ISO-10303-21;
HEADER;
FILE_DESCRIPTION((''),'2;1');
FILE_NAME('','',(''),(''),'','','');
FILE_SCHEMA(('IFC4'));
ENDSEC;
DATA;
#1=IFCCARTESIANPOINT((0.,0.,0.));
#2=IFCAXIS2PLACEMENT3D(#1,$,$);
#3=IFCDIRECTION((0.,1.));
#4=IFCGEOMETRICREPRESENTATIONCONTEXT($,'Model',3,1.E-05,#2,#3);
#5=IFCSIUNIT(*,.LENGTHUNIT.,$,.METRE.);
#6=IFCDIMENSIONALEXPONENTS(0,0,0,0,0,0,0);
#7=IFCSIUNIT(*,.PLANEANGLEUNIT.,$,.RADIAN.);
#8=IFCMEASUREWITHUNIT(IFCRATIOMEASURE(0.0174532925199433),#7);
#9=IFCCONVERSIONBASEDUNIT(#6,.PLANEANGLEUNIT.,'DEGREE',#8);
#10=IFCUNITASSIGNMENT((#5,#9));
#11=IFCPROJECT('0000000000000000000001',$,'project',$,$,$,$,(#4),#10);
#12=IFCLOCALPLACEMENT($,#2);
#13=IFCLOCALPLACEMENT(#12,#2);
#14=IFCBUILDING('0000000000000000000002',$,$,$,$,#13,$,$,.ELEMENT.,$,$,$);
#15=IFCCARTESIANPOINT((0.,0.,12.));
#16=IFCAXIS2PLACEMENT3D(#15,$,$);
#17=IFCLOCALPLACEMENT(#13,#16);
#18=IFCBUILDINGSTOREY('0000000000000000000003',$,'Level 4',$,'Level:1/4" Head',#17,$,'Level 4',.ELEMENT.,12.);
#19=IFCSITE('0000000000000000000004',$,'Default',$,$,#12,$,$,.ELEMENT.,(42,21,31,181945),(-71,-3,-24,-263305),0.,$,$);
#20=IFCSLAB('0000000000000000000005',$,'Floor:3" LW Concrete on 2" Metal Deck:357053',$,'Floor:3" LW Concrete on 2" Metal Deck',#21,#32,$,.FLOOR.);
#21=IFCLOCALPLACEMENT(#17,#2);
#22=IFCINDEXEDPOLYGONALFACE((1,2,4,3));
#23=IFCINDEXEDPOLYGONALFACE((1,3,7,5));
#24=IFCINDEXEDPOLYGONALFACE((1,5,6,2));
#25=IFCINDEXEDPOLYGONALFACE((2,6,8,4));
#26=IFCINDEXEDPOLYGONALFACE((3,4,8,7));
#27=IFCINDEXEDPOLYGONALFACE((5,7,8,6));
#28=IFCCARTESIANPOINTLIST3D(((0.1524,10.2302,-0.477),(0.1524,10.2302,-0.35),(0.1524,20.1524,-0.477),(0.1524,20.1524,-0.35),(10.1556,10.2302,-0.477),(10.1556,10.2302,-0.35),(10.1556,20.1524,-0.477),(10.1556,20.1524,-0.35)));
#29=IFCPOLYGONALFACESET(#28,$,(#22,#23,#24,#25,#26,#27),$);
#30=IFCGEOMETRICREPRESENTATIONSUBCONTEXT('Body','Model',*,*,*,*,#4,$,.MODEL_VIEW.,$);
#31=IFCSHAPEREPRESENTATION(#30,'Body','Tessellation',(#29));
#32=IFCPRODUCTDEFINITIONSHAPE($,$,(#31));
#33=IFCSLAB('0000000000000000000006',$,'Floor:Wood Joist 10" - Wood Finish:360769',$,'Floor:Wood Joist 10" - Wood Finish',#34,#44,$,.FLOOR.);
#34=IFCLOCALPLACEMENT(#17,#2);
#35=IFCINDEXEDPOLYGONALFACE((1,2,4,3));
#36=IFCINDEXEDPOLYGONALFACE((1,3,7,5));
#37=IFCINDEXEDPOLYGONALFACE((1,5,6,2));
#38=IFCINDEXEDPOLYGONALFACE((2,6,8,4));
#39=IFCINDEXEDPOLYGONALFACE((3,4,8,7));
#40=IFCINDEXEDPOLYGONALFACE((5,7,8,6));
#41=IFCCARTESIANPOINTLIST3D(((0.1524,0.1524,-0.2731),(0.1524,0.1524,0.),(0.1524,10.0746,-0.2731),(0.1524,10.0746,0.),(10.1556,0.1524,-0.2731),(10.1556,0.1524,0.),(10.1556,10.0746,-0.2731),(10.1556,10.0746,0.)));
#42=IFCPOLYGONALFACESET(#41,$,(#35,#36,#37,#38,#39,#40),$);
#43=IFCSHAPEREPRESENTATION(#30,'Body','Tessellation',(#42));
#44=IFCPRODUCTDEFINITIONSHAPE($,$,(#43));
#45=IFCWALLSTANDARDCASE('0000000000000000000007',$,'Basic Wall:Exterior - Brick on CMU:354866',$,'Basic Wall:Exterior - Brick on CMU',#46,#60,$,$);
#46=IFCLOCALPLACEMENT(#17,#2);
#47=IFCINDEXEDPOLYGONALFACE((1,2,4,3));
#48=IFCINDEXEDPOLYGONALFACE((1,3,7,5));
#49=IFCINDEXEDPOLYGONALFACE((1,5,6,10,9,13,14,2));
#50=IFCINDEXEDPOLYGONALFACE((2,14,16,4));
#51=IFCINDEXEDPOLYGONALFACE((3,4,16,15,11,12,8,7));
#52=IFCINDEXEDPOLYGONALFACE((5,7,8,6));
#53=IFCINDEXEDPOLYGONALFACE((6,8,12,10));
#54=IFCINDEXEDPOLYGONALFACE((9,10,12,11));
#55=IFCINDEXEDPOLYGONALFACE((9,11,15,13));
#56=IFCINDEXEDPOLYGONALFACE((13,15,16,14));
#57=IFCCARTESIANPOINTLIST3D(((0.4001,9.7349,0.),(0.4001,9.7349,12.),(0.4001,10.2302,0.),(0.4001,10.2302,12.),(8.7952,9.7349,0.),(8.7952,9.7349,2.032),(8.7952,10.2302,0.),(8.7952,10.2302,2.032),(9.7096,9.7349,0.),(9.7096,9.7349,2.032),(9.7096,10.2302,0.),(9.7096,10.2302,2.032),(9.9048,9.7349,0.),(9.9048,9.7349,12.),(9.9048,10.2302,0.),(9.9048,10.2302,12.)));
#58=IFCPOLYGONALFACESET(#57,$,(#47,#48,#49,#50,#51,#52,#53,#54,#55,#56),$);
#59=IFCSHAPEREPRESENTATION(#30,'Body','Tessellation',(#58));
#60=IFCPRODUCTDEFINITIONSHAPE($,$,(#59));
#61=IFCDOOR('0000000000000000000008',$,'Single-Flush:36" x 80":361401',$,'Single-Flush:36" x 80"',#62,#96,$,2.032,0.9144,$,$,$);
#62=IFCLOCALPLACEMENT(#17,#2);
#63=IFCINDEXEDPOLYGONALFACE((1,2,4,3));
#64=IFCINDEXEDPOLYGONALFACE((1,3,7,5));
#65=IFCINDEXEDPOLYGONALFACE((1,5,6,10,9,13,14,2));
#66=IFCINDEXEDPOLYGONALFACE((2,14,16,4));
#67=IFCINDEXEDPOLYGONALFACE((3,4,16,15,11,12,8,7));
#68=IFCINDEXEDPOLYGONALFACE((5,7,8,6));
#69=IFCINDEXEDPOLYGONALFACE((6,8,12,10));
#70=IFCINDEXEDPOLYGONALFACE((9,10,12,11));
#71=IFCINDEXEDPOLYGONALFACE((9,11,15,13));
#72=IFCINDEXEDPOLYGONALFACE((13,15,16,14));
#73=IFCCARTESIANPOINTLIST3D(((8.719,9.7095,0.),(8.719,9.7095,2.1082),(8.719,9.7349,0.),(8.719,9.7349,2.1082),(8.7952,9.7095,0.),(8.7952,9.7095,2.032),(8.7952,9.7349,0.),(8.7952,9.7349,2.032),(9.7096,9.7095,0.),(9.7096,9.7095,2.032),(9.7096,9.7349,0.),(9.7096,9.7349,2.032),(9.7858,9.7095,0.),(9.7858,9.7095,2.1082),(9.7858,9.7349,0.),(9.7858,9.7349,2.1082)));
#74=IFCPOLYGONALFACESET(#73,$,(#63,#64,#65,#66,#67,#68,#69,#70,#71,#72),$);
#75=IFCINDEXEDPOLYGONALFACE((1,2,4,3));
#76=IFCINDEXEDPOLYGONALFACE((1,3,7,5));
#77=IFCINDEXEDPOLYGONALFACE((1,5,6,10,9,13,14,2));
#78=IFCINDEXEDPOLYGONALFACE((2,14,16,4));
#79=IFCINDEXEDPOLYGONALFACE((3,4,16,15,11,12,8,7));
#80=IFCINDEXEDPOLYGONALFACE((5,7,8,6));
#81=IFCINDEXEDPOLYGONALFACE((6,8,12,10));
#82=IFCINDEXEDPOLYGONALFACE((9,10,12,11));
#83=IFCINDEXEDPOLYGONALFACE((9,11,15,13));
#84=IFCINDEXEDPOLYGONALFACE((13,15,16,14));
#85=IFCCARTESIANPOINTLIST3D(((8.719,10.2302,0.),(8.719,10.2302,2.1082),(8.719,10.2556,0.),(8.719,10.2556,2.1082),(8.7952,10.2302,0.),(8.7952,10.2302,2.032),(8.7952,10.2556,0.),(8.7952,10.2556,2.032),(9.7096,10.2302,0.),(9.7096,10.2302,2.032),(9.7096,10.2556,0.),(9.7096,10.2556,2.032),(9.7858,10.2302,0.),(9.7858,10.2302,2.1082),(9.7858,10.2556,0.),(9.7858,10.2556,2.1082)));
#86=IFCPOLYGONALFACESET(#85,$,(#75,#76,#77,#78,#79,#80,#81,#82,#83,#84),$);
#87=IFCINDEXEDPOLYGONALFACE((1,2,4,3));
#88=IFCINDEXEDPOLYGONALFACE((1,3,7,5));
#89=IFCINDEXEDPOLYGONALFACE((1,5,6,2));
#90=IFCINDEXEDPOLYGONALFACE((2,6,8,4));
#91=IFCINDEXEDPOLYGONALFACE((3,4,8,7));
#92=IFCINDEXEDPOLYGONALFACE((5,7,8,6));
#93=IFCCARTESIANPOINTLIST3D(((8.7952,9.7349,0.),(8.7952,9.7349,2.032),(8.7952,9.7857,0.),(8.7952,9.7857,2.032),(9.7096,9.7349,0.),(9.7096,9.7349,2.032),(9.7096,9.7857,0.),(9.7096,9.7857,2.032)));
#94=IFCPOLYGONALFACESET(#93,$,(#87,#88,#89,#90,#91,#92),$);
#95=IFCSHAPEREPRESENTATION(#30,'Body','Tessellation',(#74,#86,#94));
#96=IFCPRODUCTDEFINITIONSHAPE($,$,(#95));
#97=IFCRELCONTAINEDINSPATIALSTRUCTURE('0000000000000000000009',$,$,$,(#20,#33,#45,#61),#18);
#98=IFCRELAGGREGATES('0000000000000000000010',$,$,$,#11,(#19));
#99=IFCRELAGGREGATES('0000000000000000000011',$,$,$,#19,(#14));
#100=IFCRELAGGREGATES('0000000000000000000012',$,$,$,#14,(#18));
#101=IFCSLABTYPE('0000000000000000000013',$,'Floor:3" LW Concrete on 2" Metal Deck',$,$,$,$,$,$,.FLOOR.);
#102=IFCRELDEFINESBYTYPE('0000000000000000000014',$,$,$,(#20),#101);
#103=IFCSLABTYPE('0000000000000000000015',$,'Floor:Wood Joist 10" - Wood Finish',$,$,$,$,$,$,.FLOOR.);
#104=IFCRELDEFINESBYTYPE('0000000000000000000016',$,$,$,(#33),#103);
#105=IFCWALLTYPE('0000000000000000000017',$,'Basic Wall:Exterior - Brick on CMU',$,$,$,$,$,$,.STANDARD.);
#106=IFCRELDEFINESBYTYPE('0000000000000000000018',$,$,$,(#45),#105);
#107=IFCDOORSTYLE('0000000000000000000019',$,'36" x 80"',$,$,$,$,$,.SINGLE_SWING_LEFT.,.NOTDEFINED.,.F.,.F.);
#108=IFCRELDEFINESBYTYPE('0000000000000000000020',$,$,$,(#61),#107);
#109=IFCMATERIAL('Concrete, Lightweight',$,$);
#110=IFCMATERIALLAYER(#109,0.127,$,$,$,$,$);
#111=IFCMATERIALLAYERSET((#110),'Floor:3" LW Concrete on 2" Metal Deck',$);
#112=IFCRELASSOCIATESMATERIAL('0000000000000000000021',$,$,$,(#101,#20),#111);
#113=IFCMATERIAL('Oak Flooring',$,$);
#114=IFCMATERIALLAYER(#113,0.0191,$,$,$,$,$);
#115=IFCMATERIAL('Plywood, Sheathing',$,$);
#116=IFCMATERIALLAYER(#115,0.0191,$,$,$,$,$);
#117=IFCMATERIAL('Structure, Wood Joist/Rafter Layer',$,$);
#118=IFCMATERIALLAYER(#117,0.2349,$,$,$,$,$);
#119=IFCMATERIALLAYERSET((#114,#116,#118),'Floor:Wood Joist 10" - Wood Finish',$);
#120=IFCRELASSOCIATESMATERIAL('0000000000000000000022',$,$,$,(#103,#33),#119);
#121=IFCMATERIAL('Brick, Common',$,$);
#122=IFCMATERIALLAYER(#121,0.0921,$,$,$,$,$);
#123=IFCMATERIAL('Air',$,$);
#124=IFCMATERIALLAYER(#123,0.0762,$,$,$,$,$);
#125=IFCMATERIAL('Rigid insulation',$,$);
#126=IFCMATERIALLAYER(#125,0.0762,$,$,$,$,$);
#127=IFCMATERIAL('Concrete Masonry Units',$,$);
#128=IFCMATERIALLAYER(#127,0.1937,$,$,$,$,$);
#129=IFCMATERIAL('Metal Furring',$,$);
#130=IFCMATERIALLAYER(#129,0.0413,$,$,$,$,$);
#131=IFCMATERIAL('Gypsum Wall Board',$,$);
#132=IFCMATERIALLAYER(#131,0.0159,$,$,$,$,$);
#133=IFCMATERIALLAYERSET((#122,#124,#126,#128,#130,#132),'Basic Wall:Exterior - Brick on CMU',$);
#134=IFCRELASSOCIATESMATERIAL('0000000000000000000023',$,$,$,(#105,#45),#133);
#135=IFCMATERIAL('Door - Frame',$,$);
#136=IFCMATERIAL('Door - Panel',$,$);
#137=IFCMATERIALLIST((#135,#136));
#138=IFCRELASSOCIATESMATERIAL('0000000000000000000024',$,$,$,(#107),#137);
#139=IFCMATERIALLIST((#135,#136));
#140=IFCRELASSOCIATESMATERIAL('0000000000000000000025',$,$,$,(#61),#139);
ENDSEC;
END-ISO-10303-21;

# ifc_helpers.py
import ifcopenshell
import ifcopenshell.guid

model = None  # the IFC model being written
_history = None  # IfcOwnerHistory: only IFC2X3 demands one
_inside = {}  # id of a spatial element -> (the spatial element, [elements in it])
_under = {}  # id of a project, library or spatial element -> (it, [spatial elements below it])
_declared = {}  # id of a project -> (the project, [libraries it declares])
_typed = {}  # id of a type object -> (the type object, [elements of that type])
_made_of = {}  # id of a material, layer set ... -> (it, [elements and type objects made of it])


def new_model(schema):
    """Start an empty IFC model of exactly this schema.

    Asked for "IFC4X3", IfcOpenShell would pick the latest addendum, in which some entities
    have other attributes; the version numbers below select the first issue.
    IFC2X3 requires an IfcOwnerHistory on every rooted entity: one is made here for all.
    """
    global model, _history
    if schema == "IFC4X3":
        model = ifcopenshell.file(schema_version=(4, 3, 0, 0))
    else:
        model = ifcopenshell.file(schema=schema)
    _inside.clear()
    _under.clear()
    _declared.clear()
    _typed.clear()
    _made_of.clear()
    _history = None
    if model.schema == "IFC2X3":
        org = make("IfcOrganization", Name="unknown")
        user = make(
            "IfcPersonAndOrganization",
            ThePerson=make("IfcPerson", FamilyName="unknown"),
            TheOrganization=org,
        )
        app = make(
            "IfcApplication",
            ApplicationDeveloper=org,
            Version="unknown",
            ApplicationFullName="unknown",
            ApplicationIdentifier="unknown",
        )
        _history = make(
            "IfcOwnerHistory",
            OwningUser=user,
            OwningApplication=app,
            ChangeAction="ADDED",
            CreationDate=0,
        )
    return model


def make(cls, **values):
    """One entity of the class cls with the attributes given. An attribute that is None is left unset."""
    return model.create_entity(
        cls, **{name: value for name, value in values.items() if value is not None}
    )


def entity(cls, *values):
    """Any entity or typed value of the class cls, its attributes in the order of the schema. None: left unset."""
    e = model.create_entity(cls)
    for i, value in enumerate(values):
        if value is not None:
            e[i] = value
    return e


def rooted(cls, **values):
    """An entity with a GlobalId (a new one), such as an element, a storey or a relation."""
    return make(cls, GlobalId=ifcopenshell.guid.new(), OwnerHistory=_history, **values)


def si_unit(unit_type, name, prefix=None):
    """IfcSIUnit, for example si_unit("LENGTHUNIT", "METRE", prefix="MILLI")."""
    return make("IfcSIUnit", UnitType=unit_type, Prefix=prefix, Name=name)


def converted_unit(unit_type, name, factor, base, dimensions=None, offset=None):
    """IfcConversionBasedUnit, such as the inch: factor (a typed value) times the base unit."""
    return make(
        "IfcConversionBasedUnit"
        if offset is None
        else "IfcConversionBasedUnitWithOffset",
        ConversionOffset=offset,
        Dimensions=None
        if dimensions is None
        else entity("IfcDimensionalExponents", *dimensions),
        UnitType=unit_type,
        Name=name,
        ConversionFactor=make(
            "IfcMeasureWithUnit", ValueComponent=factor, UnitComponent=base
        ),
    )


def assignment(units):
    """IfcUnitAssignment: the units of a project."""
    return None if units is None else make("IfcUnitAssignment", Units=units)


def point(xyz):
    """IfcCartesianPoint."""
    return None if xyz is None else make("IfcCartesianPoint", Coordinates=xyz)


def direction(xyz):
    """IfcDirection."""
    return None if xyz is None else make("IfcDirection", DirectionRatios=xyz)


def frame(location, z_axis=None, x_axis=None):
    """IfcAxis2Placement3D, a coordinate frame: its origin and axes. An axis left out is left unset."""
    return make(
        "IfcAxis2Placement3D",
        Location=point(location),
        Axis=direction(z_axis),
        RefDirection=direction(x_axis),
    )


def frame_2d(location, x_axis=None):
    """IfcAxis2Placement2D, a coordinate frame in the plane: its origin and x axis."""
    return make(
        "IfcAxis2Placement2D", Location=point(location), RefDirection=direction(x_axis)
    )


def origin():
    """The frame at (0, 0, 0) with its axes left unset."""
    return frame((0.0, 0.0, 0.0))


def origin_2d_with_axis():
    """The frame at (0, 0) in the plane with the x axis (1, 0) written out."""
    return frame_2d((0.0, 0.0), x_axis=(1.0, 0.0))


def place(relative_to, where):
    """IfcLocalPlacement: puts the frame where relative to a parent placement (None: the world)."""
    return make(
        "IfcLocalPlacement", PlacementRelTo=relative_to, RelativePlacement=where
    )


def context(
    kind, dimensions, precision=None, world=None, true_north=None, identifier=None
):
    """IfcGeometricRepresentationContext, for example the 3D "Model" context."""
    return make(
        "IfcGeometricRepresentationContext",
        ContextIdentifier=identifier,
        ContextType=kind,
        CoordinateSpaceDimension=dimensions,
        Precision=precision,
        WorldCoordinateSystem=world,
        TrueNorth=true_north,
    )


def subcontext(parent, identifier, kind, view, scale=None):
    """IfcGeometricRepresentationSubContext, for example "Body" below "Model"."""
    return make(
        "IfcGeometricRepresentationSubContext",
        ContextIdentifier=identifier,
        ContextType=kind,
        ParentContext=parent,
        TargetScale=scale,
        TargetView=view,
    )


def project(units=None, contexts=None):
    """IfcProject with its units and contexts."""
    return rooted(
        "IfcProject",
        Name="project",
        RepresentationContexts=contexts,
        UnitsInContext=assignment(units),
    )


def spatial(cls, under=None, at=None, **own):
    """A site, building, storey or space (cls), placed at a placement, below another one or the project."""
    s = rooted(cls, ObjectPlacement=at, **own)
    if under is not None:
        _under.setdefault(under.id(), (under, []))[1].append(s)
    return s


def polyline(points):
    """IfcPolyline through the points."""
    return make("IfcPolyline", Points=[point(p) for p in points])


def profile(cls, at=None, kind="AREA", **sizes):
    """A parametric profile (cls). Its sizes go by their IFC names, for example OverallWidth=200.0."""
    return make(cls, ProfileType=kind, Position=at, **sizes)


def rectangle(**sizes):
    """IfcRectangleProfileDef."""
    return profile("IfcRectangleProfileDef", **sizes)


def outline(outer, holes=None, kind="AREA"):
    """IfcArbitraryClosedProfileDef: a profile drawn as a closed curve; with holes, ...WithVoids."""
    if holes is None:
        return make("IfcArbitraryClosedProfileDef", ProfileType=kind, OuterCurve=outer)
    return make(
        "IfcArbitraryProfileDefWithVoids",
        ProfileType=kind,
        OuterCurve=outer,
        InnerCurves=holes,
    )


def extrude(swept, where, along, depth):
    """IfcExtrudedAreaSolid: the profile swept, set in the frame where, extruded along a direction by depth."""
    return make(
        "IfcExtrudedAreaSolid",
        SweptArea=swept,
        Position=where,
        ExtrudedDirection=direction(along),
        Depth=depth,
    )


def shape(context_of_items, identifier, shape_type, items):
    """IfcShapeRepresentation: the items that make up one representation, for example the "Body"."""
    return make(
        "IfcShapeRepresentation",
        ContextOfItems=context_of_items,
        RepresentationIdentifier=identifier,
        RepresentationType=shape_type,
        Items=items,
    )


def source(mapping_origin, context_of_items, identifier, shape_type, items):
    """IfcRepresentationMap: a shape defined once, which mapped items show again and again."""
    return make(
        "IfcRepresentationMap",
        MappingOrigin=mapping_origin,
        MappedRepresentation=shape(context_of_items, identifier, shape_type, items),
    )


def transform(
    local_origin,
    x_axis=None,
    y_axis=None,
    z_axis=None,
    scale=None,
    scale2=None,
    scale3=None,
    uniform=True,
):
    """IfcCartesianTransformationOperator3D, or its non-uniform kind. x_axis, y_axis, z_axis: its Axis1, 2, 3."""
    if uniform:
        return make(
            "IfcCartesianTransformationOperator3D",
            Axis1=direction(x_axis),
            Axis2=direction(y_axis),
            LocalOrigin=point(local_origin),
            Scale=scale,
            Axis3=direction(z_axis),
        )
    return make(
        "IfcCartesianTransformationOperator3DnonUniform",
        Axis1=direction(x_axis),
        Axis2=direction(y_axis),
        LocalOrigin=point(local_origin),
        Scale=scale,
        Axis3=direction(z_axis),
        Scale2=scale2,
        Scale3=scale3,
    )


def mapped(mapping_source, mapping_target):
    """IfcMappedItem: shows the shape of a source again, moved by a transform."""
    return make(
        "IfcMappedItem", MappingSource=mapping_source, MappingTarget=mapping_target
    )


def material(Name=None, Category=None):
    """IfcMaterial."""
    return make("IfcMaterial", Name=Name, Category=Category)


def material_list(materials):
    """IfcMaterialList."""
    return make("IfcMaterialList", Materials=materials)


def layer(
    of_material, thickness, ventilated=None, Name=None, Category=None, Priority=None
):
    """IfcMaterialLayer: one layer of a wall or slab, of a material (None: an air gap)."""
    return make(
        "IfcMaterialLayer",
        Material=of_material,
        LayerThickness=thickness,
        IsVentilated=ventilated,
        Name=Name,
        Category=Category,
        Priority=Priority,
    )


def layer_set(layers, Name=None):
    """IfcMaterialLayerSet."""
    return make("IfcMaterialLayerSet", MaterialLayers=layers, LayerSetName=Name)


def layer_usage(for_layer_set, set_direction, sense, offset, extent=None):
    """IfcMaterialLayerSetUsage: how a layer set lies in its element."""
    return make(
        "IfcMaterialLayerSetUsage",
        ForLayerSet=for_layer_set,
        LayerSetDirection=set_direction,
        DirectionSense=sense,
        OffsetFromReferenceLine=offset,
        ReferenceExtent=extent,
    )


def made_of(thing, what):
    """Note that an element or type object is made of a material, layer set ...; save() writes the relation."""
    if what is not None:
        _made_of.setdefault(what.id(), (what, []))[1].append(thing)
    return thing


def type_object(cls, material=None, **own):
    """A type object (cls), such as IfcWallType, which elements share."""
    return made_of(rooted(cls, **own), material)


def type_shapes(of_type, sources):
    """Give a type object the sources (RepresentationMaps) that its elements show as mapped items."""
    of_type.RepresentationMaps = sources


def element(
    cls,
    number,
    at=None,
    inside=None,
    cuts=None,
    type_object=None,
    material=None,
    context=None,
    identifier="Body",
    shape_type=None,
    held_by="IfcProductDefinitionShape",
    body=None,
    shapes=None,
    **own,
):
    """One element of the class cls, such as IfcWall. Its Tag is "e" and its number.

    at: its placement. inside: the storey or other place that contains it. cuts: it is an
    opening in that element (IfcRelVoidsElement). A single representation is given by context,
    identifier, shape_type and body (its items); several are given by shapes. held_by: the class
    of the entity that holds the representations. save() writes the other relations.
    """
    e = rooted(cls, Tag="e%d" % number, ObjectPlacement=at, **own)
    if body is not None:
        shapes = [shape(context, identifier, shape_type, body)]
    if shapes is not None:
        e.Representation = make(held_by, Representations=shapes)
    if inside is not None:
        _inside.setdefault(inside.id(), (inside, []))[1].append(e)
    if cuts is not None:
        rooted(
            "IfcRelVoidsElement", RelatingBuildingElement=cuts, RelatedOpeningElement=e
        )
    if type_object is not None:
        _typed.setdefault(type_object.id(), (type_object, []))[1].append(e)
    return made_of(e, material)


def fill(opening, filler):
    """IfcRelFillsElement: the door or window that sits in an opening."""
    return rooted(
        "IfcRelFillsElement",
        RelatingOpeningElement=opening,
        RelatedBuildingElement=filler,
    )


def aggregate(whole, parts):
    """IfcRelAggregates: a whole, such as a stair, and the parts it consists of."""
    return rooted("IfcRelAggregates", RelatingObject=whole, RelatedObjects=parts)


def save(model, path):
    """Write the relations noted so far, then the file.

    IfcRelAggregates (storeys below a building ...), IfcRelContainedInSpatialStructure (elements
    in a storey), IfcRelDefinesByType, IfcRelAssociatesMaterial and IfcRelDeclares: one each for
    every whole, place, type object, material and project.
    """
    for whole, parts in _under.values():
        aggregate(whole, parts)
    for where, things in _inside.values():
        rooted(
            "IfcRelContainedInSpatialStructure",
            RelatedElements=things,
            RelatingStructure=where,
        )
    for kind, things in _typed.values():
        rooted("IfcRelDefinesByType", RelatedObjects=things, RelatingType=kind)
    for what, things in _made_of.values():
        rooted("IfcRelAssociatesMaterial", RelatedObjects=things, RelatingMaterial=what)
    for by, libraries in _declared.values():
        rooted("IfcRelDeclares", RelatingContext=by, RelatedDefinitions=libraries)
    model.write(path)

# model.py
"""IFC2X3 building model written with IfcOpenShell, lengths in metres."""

from ifc_helpers import new_model, entity, si_unit, converted_unit, direction, frame, frame_2d, origin, origin_2d_with_axis, place, context, subcontext, project, spatial, polyline, rectangle, outline, extrude, source, transform, mapped, material, material_list, layer, layer_set, layer_usage, type_object, type_shapes, element, fill, save


model = new_model("IFC2X3")

# Units and contexts
model_context = context("Model", 3, precision=1e-05, world=origin(), true_north=direction((0.0, 1.0)))
body_context = subcontext(model_context, "Body", "Model", "MODEL_VIEW")
ifc_project = project(units=[si_unit("LENGTHUNIT", "METRE"), converted_unit("PLANEANGLEUNIT", "DEGREE", entity("IfcRatioMeasure", 0.0174532925199433), si_unit("PLANEANGLEUNIT", "RADIAN"), dimensions=[0, 0, 0, 0, 0, 0, 0])], contexts=[model_context])

# Site, building, storey
site_placement = place(None, origin())
site = spatial("IfcSite", under=ifc_project, at=site_placement, Name="Default", CompositionType="ELEMENT", RefLatitude=(42, 21, 31, 181945), RefLongitude=(-71, -3, -24, -263305), RefElevation=0.0)
building_placement = place(site_placement, origin())
building = spatial("IfcBuilding", under=site, at=building_placement, CompositionType="ELEMENT")
storey_placement = place(building_placement, frame((0.0, 0.0, 12.0)))
storey = spatial("IfcBuildingStorey", under=building, at=storey_placement, Name="Level 4", ObjectType="Level:1/4\" Head", LongName="Level 4", CompositionType="ELEMENT", Elevation=12.0)

# Slabs
ifc_material_1 = material(Name="Concrete, Lightweight")
ifc_layer_1 = layer(ifc_material_1, 0.127)
ifc_layer_set_1 = layer_set([ifc_layer_1], Name="Floor:3\" LW Concrete on 2\" Metal Deck")
ifc_layer_usage_1 = layer_usage(ifc_layer_set_1, "AXIS3", "POSITIVE", 0.0)
slab_type_1 = type_object("IfcSlabType", Name="Floor:3\" LW Concrete on 2\" Metal Deck", PredefinedType="FLOOR", material=ifc_layer_set_1)
slab_1_placement = place(storey_placement, origin())
element("IfcSlab", 1, at=slab_1_placement, inside=storey, type_object=slab_type_1, material=ifc_layer_usage_1, Name="Floor:3\" LW Concrete on 2\" Metal Deck:357053", ObjectType="Floor:3\" LW Concrete on 2\" Metal Deck", PredefinedType="FLOOR", context=body_context, shape_type="SweptSolid", body=[
    extrude(rectangle(XDim=9.9222, YDim=10.0032, at=frame_2d((0.0, 0.0), x_axis=(1.0, 0.0))), frame((5.154, 15.1913, -0.35), z_axis=(0.0, 0.0, -1.0), x_axis=(0.0, 1.0, 0.0)), (0.0, 0.0, 1.0), 0.127),
])
ifc_material_2 = material(Name="Oak Flooring")
ifc_layer_2 = layer(ifc_material_2, 0.0191)
ifc_material_3 = material(Name="Plywood, Sheathing")
ifc_layer_3 = layer(ifc_material_3, 0.0191)
ifc_material_4 = material(Name="Structure, Wood Joist/Rafter Layer")
ifc_layer_4 = layer(ifc_material_4, 0.2349)
ifc_layer_set_2 = layer_set([ifc_layer_2, ifc_layer_3, ifc_layer_4], Name="Floor:Wood Joist 10\" - Wood Finish")
ifc_layer_usage_2 = layer_usage(ifc_layer_set_2, "AXIS3", "POSITIVE", 0.0)
slab_type_2 = type_object("IfcSlabType", Name="Floor:Wood Joist 10\" - Wood Finish", PredefinedType="FLOOR", material=ifc_layer_set_2)
slab_2_placement = place(storey_placement, origin())
element("IfcSlab", 2, at=slab_2_placement, inside=storey, type_object=slab_type_2, material=ifc_layer_usage_2, Name="Floor:Wood Joist 10\" - Wood Finish:360769", ObjectType="Floor:Wood Joist 10\" - Wood Finish", PredefinedType="FLOOR", context=body_context, shape_type="SweptSolid", body=[
    extrude(rectangle(XDim=9.9222, YDim=10.0032, at=origin_2d_with_axis()), frame((5.154, 5.1135, 0.0), z_axis=(0.0, 0.0, -1.0), x_axis=(0.0, 1.0, 0.0)), (0.0, 0.0, 1.0), 0.2731),
])

# Wall, opening, door
ifc_material_5 = material(Name="Brick, Common")
ifc_layer_5 = layer(ifc_material_5, 0.0921)
ifc_material_6 = material(Name="Air")
ifc_layer_6 = layer(ifc_material_6, 0.0762)
ifc_material_7 = material(Name="Rigid insulation")
ifc_layer_7 = layer(ifc_material_7, 0.0762)
ifc_material_8 = material(Name="Concrete Masonry Units")
ifc_layer_8 = layer(ifc_material_8, 0.1937)
ifc_material_9 = material(Name="Metal Furring")
ifc_layer_9 = layer(ifc_material_9, 0.0413)
ifc_material_10 = material(Name="Gypsum Wall Board")
ifc_layer_10 = layer(ifc_material_10, 0.0159)
ifc_layer_set_3 = layer_set([ifc_layer_5, ifc_layer_6, ifc_layer_7, ifc_layer_8, ifc_layer_9, ifc_layer_10], Name="Basic Wall:Exterior - Brick on CMU")
ifc_layer_usage_3 = layer_usage(ifc_layer_set_3, "AXIS2", "POSITIVE", -0.2477)
wall_type = type_object("IfcWallType", Name="Basic Wall:Exterior - Brick on CMU", PredefinedType="STANDARD", material=ifc_layer_set_3)
wall_placement = place(storey_placement, frame((9.9048, 9.9825, 0.0), z_axis=(0.0, 0.0, 1.0), x_axis=(-1.0, 0.0, 0.0)))
wall = element("IfcWallStandardCase", 3, at=wall_placement, inside=storey, type_object=wall_type, material=ifc_layer_usage_3, Name="Basic Wall:Exterior - Brick on CMU:354866", ObjectType="Basic Wall:Exterior - Brick on CMU", context=body_context, shape_type="SweptSolid", body=[
    extrude(rectangle(XDim=9.5047, YDim=0.4953, at=frame_2d((4.7523, 0.0), x_axis=(-1.0, 0.0))), origin(), (0.0, 0.0, 1.0), 12.0),
])
opening_placement = place(wall_placement, frame((0.1952, -0.2477, 0.0)))
opening = element("IfcOpeningElement", 4, at=opening_placement, cuts=wall, ObjectType="Opening", context=body_context, shape_type="SweptSolid", body=[
    extrude(rectangle(XDim=0.9144, YDim=2.032, at=frame_2d((1.016, 0.4572), x_axis=(0.0, -1.0))), frame((0.0, 0.0, 0.0), z_axis=(0.0, 1.0, 0.0), x_axis=(0.0, 0.0, 1.0)), (0.0, 0.0, 1.0), 0.4953),
])
ifc_material_11 = material(Name="Door - Frame")
ifc_material_12 = material(Name="Door - Panel")
ifc_material_list_1 = material_list([ifc_material_11, ifc_material_12])
ifc_material_list_2 = material_list([ifc_material_11, ifc_material_12])
door_style = type_object("IfcDoorStyle", Name="36\" x 80\"", ConstructionType="NOTDEFINED", OperationType="SINGLE_SWING_LEFT", ParameterTakesPrecedence=False, Sizeable=False, material=ifc_material_list_2)
shared_shape = source(origin(), body_context, "Body", "SweptSolid", [
    extrude(outline(polyline([(-0.5334, -1.0732), (0.5334, -1.0732), (0.5334, 1.0351), (0.4572, 1.0351), (0.4572, -0.997), (-0.4572, -0.997), (-0.4572, 1.0351), (-0.5334, 1.0351), (-0.5334, -1.0732)])), frame((0.4572, 0.5207, 1.0351), z_axis=(0.0, -1.0, 0.0), x_axis=(-1.0, 0.0, 0.0)), (0.0, 0.0, 1.0), 0.0254),
    extrude(outline(polyline([(-1.0732, -0.5334), (1.0351, -0.5334), (1.0351, -0.4572), (-0.997, -0.4572), (-0.997, 0.4572), (1.0351, 0.4572), (1.0351, 0.5334), (-1.0732, 0.5334), (-1.0732, -0.5334)])), frame((0.4572, 0.0, 1.0351), z_axis=(0.0, -1.0, 0.0), x_axis=(0.0, 0.0, -1.0)), (0.0, 0.0, 1.0), 0.0254),
    extrude(rectangle(XDim=0.9144, YDim=0.0508, at=frame_2d((0.0, 0.0), x_axis=(1.0, 0.0))), frame((0.4572, 0.4699, 0.0)), (0.0, 0.0, 1.0), 2.032),
])
type_shapes(door_style, [shared_shape])
door_placement = place(opening_placement, origin())
door = element("IfcDoor", 5, at=door_placement, inside=storey, type_object=door_style, material=ifc_material_list_1, Name="Single-Flush:36\" x 80\":361401", ObjectType="Single-Flush:36\" x 80\"", OverallHeight=2.032, OverallWidth=0.9144, context=body_context, shape_type="MappedRepresentation", body=[
    mapped(shared_shape, transform((0.0, 0.0, 0.0), scale=1.0)),
])
fill(opening, door)

save(model, "model.ifc")
